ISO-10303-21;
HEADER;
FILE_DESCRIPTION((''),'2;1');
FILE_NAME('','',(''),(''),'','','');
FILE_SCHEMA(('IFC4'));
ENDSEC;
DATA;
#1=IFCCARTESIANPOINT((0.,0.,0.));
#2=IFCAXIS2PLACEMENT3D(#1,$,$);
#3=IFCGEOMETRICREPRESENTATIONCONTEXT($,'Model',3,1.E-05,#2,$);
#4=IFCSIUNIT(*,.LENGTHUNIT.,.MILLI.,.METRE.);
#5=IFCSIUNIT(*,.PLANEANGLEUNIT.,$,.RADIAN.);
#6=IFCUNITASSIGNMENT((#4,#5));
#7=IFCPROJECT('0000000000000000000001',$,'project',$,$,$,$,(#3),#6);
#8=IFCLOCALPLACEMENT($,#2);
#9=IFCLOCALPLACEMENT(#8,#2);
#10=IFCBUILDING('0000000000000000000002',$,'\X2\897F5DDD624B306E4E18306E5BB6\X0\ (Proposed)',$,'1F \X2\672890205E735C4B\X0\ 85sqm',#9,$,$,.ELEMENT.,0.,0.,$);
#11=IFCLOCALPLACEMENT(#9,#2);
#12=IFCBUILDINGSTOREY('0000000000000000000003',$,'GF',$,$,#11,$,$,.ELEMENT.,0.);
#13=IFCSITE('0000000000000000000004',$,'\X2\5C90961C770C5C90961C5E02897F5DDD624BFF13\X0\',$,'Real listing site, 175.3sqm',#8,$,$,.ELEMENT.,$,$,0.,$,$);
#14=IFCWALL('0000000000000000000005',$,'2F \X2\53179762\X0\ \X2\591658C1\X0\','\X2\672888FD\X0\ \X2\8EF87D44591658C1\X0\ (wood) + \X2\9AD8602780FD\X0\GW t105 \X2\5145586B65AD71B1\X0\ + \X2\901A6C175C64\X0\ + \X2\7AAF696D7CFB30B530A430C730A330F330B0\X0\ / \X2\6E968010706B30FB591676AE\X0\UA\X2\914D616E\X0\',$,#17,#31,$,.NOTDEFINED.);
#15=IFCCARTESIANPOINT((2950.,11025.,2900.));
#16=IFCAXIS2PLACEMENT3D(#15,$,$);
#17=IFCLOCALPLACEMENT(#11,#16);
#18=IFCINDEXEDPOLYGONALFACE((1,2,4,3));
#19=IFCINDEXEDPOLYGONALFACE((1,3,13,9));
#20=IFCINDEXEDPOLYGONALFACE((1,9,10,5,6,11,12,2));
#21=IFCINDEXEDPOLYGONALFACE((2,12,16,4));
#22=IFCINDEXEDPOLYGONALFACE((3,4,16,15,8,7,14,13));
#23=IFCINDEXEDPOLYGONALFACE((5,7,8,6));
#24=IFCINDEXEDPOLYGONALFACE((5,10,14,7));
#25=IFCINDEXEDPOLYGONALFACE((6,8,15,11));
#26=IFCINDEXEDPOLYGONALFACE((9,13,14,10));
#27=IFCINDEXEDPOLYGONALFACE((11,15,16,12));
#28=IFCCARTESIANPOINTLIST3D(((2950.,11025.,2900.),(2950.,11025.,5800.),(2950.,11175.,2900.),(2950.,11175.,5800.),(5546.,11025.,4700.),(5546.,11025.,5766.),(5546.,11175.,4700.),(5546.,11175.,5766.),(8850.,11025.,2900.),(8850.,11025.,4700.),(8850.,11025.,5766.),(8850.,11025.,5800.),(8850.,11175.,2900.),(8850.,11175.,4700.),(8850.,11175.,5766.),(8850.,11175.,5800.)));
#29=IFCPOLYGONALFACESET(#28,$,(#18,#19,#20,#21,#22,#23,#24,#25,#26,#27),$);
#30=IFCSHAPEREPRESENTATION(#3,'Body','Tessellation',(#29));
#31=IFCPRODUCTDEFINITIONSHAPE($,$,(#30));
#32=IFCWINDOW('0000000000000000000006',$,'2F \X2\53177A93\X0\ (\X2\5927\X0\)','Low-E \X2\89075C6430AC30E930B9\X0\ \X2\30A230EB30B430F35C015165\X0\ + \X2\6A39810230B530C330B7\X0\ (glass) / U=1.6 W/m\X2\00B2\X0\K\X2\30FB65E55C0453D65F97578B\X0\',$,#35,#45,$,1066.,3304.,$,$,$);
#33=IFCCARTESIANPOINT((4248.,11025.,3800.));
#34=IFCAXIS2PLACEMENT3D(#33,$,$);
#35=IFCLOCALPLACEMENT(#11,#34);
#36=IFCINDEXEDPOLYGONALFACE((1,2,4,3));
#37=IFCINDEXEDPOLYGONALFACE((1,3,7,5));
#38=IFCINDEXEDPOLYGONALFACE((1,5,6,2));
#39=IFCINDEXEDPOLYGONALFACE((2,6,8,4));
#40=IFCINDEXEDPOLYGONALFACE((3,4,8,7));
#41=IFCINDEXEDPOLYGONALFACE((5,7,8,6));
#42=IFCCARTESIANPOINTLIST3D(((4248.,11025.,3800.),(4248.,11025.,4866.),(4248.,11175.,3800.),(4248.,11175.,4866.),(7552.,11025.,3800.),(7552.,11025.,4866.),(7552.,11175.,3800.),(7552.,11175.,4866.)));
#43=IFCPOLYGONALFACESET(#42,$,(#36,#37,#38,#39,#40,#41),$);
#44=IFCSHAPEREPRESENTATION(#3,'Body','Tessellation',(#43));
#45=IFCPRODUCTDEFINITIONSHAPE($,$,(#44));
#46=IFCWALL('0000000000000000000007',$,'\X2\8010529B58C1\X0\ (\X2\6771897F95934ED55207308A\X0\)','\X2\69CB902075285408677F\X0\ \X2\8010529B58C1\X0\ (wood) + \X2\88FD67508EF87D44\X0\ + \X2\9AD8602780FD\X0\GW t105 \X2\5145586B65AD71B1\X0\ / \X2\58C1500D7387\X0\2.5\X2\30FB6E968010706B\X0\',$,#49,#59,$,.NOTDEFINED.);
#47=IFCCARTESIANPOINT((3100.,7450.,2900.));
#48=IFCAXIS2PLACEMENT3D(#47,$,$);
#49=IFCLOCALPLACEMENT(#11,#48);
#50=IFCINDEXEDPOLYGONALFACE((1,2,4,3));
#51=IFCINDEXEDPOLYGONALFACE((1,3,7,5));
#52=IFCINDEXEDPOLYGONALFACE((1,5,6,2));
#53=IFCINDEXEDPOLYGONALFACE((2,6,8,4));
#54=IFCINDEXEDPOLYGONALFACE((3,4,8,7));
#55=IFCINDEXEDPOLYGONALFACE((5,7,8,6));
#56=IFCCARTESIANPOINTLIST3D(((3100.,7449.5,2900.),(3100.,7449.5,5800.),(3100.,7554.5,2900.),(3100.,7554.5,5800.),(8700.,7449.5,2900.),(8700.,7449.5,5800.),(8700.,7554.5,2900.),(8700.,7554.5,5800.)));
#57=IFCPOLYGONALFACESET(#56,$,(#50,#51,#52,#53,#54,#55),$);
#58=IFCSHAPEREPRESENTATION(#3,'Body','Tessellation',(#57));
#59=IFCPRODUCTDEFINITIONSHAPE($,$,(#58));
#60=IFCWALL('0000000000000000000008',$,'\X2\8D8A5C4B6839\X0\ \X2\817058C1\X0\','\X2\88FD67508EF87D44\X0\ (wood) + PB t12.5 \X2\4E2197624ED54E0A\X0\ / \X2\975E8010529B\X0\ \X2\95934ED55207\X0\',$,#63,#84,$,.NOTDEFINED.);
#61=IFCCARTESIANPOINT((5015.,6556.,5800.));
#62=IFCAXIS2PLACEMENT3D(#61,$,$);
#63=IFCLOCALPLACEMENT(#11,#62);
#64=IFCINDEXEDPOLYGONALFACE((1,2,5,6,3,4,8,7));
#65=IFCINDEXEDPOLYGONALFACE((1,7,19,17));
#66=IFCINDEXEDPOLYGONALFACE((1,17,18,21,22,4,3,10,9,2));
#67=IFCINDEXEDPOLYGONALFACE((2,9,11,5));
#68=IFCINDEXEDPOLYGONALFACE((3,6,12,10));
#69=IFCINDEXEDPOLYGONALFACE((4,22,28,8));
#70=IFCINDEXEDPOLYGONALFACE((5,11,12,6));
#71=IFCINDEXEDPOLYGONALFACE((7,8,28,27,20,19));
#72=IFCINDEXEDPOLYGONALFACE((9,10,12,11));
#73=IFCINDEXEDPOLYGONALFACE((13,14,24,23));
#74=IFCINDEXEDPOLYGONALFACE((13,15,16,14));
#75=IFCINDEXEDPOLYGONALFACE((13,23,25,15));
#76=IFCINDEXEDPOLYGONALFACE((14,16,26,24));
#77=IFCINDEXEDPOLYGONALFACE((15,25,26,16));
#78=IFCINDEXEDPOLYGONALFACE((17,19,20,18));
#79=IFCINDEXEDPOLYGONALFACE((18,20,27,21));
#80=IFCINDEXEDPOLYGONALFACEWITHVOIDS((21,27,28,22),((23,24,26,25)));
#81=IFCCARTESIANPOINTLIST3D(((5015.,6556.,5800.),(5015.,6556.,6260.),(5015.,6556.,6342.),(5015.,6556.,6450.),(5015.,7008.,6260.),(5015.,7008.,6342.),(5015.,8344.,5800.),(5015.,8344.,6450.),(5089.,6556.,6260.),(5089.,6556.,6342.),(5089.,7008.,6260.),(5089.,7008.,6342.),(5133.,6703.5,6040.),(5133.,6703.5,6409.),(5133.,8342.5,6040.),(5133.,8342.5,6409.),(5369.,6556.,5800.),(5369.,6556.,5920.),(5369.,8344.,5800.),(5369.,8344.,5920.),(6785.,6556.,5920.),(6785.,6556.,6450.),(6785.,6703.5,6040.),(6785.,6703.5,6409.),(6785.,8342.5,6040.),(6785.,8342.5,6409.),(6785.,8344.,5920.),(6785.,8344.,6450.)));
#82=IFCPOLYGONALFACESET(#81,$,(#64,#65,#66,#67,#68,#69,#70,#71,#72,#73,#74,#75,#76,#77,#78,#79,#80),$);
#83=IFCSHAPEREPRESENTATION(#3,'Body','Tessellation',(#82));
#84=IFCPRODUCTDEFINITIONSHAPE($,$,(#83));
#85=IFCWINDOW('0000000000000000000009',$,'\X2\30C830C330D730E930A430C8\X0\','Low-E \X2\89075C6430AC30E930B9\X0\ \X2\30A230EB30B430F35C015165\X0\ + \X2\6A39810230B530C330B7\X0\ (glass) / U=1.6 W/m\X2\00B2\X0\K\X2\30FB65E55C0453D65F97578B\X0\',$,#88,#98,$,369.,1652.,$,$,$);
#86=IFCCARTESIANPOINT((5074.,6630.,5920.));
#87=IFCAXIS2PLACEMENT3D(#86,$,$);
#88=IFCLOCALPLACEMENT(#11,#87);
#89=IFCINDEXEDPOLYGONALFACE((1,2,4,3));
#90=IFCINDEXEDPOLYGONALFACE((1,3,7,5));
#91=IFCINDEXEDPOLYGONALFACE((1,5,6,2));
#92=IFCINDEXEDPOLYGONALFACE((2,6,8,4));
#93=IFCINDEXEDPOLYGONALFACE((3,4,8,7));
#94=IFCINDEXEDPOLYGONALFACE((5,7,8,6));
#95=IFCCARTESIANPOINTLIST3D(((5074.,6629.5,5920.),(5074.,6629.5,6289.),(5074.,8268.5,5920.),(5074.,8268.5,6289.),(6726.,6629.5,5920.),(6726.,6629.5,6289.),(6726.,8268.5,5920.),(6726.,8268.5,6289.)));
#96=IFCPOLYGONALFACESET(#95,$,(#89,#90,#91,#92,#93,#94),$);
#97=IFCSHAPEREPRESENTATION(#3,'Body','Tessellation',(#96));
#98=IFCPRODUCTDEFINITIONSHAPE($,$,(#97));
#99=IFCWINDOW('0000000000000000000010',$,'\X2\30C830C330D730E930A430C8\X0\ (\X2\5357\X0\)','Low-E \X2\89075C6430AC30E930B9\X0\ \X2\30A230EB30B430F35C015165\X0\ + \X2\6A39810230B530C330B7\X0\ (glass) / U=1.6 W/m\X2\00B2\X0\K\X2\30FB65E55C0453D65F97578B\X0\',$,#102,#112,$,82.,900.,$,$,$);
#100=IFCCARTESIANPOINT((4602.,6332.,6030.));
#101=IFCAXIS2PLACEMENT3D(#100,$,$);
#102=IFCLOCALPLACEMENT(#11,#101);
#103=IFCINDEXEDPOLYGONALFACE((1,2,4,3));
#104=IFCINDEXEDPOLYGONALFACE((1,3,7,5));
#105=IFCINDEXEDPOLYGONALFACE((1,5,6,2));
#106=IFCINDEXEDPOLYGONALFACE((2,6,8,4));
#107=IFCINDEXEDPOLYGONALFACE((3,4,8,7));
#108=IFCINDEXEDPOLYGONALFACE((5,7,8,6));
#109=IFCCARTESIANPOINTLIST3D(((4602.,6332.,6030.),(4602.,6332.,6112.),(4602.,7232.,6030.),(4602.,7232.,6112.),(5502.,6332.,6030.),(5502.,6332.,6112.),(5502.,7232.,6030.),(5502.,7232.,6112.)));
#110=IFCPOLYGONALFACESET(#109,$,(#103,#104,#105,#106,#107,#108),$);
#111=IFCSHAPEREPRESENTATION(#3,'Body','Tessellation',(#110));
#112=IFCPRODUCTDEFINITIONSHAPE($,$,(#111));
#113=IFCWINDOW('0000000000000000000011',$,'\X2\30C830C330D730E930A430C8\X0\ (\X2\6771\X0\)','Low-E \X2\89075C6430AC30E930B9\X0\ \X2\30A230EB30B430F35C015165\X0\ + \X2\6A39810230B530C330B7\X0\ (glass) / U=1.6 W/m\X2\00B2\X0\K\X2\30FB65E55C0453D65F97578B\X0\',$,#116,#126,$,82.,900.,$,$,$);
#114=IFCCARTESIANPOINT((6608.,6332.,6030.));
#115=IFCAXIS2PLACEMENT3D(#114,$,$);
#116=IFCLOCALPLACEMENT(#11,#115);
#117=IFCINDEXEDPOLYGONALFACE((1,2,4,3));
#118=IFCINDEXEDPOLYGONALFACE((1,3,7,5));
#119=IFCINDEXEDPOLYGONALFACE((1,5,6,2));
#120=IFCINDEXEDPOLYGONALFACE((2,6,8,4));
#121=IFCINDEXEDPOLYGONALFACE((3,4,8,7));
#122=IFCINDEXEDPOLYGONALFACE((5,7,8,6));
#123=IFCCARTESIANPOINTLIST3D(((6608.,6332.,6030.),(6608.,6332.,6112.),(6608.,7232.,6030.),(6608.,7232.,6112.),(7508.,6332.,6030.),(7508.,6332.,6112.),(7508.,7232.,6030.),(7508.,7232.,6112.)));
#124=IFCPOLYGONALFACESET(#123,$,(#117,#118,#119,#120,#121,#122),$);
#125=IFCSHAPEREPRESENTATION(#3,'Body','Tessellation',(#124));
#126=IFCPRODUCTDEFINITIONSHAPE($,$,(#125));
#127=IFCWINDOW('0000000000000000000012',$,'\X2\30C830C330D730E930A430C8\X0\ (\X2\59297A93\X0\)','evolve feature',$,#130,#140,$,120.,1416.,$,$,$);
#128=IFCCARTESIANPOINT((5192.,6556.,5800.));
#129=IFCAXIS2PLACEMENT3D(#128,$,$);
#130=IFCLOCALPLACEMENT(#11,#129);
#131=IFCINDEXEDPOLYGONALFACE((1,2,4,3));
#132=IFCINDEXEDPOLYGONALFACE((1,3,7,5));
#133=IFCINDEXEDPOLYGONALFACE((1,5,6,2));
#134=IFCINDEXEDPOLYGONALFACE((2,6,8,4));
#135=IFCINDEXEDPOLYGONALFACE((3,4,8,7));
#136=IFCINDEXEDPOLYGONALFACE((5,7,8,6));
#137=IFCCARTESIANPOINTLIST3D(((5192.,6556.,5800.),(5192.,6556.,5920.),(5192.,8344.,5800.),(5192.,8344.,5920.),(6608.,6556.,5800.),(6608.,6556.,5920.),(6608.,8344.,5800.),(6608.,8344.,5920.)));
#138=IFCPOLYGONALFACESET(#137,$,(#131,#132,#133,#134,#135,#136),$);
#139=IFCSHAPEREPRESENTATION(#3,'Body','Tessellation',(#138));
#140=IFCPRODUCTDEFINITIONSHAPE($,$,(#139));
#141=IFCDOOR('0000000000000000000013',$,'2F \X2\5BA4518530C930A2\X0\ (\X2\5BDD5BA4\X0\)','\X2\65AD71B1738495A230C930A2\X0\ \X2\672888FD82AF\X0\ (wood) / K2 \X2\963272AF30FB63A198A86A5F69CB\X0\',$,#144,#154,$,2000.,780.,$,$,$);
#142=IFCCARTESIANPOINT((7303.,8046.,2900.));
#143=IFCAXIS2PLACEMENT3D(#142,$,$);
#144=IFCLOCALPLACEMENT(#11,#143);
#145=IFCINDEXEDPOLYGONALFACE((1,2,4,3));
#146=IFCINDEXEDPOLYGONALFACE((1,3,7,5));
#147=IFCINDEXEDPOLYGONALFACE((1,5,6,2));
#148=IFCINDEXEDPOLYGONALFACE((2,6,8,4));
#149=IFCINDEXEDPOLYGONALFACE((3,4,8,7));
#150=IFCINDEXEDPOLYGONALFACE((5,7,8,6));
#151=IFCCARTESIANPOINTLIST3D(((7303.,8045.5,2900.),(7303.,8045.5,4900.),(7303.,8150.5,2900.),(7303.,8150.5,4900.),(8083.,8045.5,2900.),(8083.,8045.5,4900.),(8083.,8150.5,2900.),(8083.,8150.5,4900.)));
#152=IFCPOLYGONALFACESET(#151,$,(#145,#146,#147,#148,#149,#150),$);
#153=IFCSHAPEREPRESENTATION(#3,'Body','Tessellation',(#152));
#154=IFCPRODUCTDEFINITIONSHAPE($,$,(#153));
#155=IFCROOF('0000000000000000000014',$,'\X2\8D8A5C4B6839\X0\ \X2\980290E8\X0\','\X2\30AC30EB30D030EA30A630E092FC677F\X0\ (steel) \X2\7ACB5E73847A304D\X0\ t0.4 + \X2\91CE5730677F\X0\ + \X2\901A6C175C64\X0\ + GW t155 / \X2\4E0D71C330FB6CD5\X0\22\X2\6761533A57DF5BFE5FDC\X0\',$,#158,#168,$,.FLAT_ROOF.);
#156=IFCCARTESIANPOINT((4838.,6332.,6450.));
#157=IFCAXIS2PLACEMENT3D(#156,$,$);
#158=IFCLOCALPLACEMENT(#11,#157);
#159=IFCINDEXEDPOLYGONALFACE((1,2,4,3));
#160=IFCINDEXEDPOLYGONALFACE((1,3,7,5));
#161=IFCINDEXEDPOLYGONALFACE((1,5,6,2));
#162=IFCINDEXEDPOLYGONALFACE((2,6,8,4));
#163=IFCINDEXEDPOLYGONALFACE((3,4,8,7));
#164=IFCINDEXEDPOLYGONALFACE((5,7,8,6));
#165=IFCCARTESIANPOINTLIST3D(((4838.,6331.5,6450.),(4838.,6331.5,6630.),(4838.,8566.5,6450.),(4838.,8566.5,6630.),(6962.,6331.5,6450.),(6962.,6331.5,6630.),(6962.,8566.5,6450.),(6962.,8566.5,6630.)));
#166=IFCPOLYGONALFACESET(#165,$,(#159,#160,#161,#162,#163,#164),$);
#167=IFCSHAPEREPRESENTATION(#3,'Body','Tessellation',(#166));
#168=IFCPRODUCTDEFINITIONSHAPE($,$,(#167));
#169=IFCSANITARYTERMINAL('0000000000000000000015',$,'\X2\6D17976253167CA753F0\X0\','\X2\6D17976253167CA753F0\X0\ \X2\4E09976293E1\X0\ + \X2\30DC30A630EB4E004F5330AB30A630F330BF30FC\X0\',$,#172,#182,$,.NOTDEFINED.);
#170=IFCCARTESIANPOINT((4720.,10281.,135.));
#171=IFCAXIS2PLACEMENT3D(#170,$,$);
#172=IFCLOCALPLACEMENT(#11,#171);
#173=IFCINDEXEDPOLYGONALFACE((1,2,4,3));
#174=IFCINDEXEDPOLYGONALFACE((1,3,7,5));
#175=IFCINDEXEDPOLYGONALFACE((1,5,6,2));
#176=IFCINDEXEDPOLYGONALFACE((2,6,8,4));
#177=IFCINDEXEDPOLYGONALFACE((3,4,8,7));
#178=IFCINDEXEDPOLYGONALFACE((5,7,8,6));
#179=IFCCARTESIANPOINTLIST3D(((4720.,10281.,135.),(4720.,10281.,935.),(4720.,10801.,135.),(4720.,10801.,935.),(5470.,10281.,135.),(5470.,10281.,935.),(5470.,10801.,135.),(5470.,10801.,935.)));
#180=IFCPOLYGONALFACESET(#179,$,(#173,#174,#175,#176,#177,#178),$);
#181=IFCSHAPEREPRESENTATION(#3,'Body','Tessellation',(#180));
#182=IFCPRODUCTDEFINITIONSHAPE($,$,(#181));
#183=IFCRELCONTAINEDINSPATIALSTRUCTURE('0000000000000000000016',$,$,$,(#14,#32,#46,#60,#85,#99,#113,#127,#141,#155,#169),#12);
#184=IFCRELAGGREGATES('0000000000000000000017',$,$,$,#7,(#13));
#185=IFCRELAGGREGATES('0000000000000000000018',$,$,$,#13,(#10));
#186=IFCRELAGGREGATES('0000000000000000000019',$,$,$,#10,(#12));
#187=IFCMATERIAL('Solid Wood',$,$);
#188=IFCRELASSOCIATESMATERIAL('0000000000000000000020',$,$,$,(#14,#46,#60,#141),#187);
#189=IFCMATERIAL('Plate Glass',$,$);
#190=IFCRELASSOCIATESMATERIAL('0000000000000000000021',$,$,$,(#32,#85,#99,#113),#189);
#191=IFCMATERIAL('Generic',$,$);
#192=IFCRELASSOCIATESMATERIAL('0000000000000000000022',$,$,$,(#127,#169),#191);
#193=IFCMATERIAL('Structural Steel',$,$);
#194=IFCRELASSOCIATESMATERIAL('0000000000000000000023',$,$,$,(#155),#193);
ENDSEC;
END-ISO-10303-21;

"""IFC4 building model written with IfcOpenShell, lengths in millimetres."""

from ifc_helpers import new_model, si_unit, frame, frame_2d, origin, place, context, project, spatial, rectangle, extrude, material, element, fill, save


model = new_model("IFC4")

# Units and contexts
model_context = context("Model", 3, precision=1e-05, world=origin())
ifc_project = project(units=[si_unit("LENGTHUNIT", "METRE", prefix="MILLI"), si_unit("PLANEANGLEUNIT", "RADIAN")], contexts=[model_context])

# Site, building, storey
site_placement = place(None, origin())
site = spatial("IfcSite", under=ifc_project, at=site_placement, Name="岐阜県岐阜市西川手３", ObjectType="Real listing site, 175.3sqm", CompositionType="ELEMENT", RefElevation=0.0)
building_placement = place(site_placement, origin())
building = spatial("IfcBuilding", under=site, at=building_placement, Name="西川手の丘の家 (Proposed)", ObjectType="1F 木造平屋 85sqm", CompositionType="ELEMENT", ElevationOfRefHeight=0.0, ElevationOfTerrain=0.0)
storey_placement = place(building_placement, origin())
storey = spatial("IfcBuildingStorey", under=building, at=storey_placement, Name="GF", CompositionType="ELEMENT", Elevation=0.0)

# Wall, opening, window
ifc_material_1 = material(Name="Solid Wood")
wall_1_placement = place(storey_placement, frame((2950.0, 11025.0, 2900.0)))
wall_1 = element("IfcWall", 1, at=wall_1_placement, inside=storey, material=ifc_material_1, Name="2F 北面 外壁", Description="木製 軸組外壁 (wood) + 高性能GW t105 充填断熱 + 通気層 + 窯業系サイディング / 準耐火・外皮UA配慮", PredefinedType="NOTDEFINED", context=model_context, shape_type="SweptSolid", body=[
    extrude(rectangle(XDim=5900.0, YDim=150.0, at=frame_2d((2950.0, 75.0))), frame((2950.0, 11025.0, 2900.0)), (0.0, 0.0, 1.0), 2900.0),
])
opening_1_placement = place(storey_placement, frame((4248.0, 11025.0, 3800.0)))
opening_1 = element("IfcOpeningElement", 2, at=opening_1_placement, cuts=wall_1, PredefinedType="NOTDEFINED", context=model_context, shape_type="SweptSolid", body=[
    extrude(rectangle(XDim=3304.0, YDim=150.0, at=frame_2d((1652.0, 75.0))), frame((4248.0, 11025.0, 3800.0)), (0.0, 0.0, 1.0), 1066.0),
])
ifc_material_2 = material(Name="Plate Glass")
window_1_placement = place(storey_placement, frame((4248.0, 11025.0, 3800.0)))
window_1 = element("IfcWindow", 3, at=window_1_placement, inside=storey, material=ifc_material_2, Name="2F 北窓 (大)", Description="Low-E 複層ガラス アルゴン封入 + 樹脂サッシ (glass) / U=1.6 W/m²K・日射取得型", OverallHeight=1066.0, OverallWidth=3304.0, context=model_context, shape_type="SweptSolid", body=[
    extrude(rectangle(XDim=3304.0, YDim=150.0, at=frame_2d((1652.0, 75.0))), frame((4248.0, 11025.0, 3800.0)), (0.0, 0.0, 1.0), 1066.0),
])
fill(opening_1, window_1)

# Wall
wall_2_placement = place(storey_placement, frame((3100.0, 7450.0, 2900.0)))
element("IfcWall", 4, at=wall_2_placement, inside=storey, material=ifc_material_1, Name="耐力壁 (東西間仕切り)", Description="構造用合板 耐力壁 (wood) + 製材軸組 + 高性能GW t105 充填断熱 / 壁倍率2.5・準耐火", PredefinedType="NOTDEFINED", context=model_context, shape_type="SweptSolid", body=[
    extrude(rectangle(XDim=5600.0, YDim=105.0, at=frame_2d((2800.0, 52.0))), frame((3100.0, 7450.0, 2900.0)), (0.0, 0.0, 1.0), 2900.0),
])

# Wall, openings, windows
wall_3_placement = place(storey_placement, frame((5015.0, 6556.0, 5800.0)))
wall_3 = element("IfcWall", 5, at=wall_3_placement, inside=storey, material=ifc_material_1, Name="越屋根 腰壁", Description="製材軸組 (wood) + PB t12.5 両面仕上 / 非耐力 間仕切", PredefinedType="NOTDEFINED", context=model_context, shape_type="SweptSolid", body=[
    extrude(rectangle(XDim=1770.0, YDim=1788.0, at=frame_2d((885.0, 894.0))), frame((5015.0, 6556.0, 5800.0)), (0.0, 0.0, 1.0), 650.0),
])
opening_2_placement = place(storey_placement, frame((5074.0, 6630.0, 5920.0)))
opening_2 = element("IfcOpeningElement", 6, at=opening_2_placement, cuts=wall_3, PredefinedType="NOTDEFINED", context=model_context, shape_type="SweptSolid", body=[
    extrude(rectangle(XDim=1652.0, YDim=1639.0, at=frame_2d((826.0, 819.0))), frame((5074.0, 6630.0, 5920.0)), (0.0, 0.0, 1.0), 369.0),
])
opening_3_placement = place(storey_placement, frame((4602.0, 6332.0, 6030.0)))
opening_3 = element("IfcOpeningElement", 7, at=opening_3_placement, cuts=wall_3, PredefinedType="NOTDEFINED", context=model_context, shape_type="SweptSolid", body=[
    extrude(rectangle(XDim=900.0, YDim=900.0, at=frame_2d((450.0, 450.0))), frame((4602.0, 6332.0, 6030.0)), (0.0, 0.0, 1.0), 82.0),
])
opening_4_placement = place(storey_placement, frame((6608.0, 6332.0, 6030.0)))
opening_4 = element("IfcOpeningElement", 8, at=opening_4_placement, cuts=wall_3, PredefinedType="NOTDEFINED", context=model_context, shape_type="SweptSolid", body=[
    extrude(rectangle(XDim=900.0, YDim=900.0, at=frame_2d((450.0, 450.0))), frame((6608.0, 6332.0, 6030.0)), (0.0, 0.0, 1.0), 82.0),
])
opening_5_placement = place(storey_placement, frame((5192.0, 6556.0, 5800.0)))
opening_5 = element("IfcOpeningElement", 9, at=opening_5_placement, cuts=wall_3, PredefinedType="NOTDEFINED", context=model_context, shape_type="SweptSolid", body=[
    extrude(rectangle(XDim=1416.0, YDim=1788.0, at=frame_2d((708.0, 894.0))), frame((5192.0, 6556.0, 5800.0)), (0.0, 0.0, 1.0), 120.0),
])
window_2_placement = place(storey_placement, frame((5074.0, 6630.0, 5920.0)))
window_2 = element("IfcWindow", 10, at=window_2_placement, inside=storey, material=ifc_material_2, Name="トップライト", Description="Low-E 複層ガラス アルゴン封入 + 樹脂サッシ (glass) / U=1.6 W/m²K・日射取得型", OverallHeight=369.0, OverallWidth=1652.0, context=model_context, shape_type="SweptSolid", body=[
    extrude(rectangle(XDim=1652.0, YDim=1639.0, at=frame_2d((826.0, 819.0))), frame((5074.0, 6630.0, 5920.0)), (0.0, 0.0, 1.0), 369.0),
])
fill(opening_2, window_2)
window_3_placement = place(storey_placement, frame((4602.0, 6332.0, 6030.0)))
window_3 = element("IfcWindow", 11, at=window_3_placement, inside=storey, material=ifc_material_2, Name="トップライト (南)", Description="Low-E 複層ガラス アルゴン封入 + 樹脂サッシ (glass) / U=1.6 W/m²K・日射取得型", OverallHeight=82.0, OverallWidth=900.0, context=model_context, shape_type="SweptSolid", body=[
    extrude(rectangle(XDim=900.0, YDim=900.0, at=frame_2d((450.0, 450.0))), frame((4602.0, 6332.0, 6030.0)), (0.0, 0.0, 1.0), 82.0),
])
fill(opening_3, window_3)
window_4_placement = place(storey_placement, frame((6608.0, 6332.0, 6030.0)))
window_4 = element("IfcWindow", 12, at=window_4_placement, inside=storey, material=ifc_material_2, Name="トップライト (東)", Description="Low-E 複層ガラス アルゴン封入 + 樹脂サッシ (glass) / U=1.6 W/m²K・日射取得型", OverallHeight=82.0, OverallWidth=900.0, context=model_context, shape_type="SweptSolid", body=[
    extrude(rectangle(XDim=900.0, YDim=900.0, at=frame_2d((450.0, 450.0))), frame((6608.0, 6332.0, 6030.0)), (0.0, 0.0, 1.0), 82.0),
])
fill(opening_4, window_4)
ifc_material_3 = material(Name="Generic")
window_5_placement = place(storey_placement, frame((5192.0, 6556.0, 5800.0)))
window_5 = element("IfcWindow", 13, at=window_5_placement, inside=storey, material=ifc_material_3, Name="トップライト (天窓)", Description="evolve feature", OverallHeight=120.0, OverallWidth=1416.0, context=model_context, shape_type="SweptSolid", body=[
    extrude(rectangle(XDim=1416.0, YDim=1788.0, at=frame_2d((708.0, 894.0))), frame((5192.0, 6556.0, 5800.0)), (0.0, 0.0, 1.0), 120.0),
])
fill(opening_5, window_5)

# Door
door_placement = place(storey_placement, frame((7303.0, 8046.0, 2900.0)))
element("IfcDoor", 14, at=door_placement, inside=storey, material=ifc_material_1, Name="2F 室内ドア (寝室)", Description="断熱玄関ドア 木製芯 (wood) / K2 防犯・採風機構", OverallHeight=2000.0, OverallWidth=780.0, context=model_context, shape_type="SweptSolid", body=[
    extrude(rectangle(XDim=780.0, YDim=105.0, at=frame_2d((390.0, 52.0))), frame((7303.0, 8046.0, 2900.0)), (0.0, 0.0, 1.0), 2000.0),
])

# Roof
ifc_material_4 = material(Name="Structural Steel")
roof_placement = place(storey_placement, frame((4838.0, 6332.0, 6450.0)))
element("IfcRoof", 15, at=roof_placement, inside=storey, material=ifc_material_4, Name="越屋根 頂部", Description="ガルバリウム鋼板 (steel) 立平葺き t0.4 + 野地板 + 通気層 + GW t155 / 不燃・法22条区域対応", PredefinedType="FLAT_ROOF", context=model_context, shape_type="SweptSolid", body=[
    extrude(rectangle(XDim=2124.0, YDim=2235.0, at=frame_2d((1062.0, 1117.0))), frame((4838.0, 6332.0, 6450.0)), (0.0, 0.0, 1.0), 180.0),
])

# Sanitary terminal
sanitary_terminal_1_placement = place(storey_placement, frame((4720.0, 10281.0, 135.0)))
element("IfcSanitaryTerminal", 16, at=sanitary_terminal_1_placement, inside=storey, material=ifc_material_3, Name="洗面化粧台", Description="洗面化粧台 三面鏡 + ボウル一体カウンター", PredefinedType="NOTDEFINED", context=model_context, shape_type="SweptSolid", body=[
    extrude(rectangle(XDim=750.0, YDim=520.0, at=frame_2d((375.0, 260.0))), frame((4720.0, 10281.0, 135.0)), (0.0, 0.0, 1.0), 800.0),
])

save(model, "model.ifc")
